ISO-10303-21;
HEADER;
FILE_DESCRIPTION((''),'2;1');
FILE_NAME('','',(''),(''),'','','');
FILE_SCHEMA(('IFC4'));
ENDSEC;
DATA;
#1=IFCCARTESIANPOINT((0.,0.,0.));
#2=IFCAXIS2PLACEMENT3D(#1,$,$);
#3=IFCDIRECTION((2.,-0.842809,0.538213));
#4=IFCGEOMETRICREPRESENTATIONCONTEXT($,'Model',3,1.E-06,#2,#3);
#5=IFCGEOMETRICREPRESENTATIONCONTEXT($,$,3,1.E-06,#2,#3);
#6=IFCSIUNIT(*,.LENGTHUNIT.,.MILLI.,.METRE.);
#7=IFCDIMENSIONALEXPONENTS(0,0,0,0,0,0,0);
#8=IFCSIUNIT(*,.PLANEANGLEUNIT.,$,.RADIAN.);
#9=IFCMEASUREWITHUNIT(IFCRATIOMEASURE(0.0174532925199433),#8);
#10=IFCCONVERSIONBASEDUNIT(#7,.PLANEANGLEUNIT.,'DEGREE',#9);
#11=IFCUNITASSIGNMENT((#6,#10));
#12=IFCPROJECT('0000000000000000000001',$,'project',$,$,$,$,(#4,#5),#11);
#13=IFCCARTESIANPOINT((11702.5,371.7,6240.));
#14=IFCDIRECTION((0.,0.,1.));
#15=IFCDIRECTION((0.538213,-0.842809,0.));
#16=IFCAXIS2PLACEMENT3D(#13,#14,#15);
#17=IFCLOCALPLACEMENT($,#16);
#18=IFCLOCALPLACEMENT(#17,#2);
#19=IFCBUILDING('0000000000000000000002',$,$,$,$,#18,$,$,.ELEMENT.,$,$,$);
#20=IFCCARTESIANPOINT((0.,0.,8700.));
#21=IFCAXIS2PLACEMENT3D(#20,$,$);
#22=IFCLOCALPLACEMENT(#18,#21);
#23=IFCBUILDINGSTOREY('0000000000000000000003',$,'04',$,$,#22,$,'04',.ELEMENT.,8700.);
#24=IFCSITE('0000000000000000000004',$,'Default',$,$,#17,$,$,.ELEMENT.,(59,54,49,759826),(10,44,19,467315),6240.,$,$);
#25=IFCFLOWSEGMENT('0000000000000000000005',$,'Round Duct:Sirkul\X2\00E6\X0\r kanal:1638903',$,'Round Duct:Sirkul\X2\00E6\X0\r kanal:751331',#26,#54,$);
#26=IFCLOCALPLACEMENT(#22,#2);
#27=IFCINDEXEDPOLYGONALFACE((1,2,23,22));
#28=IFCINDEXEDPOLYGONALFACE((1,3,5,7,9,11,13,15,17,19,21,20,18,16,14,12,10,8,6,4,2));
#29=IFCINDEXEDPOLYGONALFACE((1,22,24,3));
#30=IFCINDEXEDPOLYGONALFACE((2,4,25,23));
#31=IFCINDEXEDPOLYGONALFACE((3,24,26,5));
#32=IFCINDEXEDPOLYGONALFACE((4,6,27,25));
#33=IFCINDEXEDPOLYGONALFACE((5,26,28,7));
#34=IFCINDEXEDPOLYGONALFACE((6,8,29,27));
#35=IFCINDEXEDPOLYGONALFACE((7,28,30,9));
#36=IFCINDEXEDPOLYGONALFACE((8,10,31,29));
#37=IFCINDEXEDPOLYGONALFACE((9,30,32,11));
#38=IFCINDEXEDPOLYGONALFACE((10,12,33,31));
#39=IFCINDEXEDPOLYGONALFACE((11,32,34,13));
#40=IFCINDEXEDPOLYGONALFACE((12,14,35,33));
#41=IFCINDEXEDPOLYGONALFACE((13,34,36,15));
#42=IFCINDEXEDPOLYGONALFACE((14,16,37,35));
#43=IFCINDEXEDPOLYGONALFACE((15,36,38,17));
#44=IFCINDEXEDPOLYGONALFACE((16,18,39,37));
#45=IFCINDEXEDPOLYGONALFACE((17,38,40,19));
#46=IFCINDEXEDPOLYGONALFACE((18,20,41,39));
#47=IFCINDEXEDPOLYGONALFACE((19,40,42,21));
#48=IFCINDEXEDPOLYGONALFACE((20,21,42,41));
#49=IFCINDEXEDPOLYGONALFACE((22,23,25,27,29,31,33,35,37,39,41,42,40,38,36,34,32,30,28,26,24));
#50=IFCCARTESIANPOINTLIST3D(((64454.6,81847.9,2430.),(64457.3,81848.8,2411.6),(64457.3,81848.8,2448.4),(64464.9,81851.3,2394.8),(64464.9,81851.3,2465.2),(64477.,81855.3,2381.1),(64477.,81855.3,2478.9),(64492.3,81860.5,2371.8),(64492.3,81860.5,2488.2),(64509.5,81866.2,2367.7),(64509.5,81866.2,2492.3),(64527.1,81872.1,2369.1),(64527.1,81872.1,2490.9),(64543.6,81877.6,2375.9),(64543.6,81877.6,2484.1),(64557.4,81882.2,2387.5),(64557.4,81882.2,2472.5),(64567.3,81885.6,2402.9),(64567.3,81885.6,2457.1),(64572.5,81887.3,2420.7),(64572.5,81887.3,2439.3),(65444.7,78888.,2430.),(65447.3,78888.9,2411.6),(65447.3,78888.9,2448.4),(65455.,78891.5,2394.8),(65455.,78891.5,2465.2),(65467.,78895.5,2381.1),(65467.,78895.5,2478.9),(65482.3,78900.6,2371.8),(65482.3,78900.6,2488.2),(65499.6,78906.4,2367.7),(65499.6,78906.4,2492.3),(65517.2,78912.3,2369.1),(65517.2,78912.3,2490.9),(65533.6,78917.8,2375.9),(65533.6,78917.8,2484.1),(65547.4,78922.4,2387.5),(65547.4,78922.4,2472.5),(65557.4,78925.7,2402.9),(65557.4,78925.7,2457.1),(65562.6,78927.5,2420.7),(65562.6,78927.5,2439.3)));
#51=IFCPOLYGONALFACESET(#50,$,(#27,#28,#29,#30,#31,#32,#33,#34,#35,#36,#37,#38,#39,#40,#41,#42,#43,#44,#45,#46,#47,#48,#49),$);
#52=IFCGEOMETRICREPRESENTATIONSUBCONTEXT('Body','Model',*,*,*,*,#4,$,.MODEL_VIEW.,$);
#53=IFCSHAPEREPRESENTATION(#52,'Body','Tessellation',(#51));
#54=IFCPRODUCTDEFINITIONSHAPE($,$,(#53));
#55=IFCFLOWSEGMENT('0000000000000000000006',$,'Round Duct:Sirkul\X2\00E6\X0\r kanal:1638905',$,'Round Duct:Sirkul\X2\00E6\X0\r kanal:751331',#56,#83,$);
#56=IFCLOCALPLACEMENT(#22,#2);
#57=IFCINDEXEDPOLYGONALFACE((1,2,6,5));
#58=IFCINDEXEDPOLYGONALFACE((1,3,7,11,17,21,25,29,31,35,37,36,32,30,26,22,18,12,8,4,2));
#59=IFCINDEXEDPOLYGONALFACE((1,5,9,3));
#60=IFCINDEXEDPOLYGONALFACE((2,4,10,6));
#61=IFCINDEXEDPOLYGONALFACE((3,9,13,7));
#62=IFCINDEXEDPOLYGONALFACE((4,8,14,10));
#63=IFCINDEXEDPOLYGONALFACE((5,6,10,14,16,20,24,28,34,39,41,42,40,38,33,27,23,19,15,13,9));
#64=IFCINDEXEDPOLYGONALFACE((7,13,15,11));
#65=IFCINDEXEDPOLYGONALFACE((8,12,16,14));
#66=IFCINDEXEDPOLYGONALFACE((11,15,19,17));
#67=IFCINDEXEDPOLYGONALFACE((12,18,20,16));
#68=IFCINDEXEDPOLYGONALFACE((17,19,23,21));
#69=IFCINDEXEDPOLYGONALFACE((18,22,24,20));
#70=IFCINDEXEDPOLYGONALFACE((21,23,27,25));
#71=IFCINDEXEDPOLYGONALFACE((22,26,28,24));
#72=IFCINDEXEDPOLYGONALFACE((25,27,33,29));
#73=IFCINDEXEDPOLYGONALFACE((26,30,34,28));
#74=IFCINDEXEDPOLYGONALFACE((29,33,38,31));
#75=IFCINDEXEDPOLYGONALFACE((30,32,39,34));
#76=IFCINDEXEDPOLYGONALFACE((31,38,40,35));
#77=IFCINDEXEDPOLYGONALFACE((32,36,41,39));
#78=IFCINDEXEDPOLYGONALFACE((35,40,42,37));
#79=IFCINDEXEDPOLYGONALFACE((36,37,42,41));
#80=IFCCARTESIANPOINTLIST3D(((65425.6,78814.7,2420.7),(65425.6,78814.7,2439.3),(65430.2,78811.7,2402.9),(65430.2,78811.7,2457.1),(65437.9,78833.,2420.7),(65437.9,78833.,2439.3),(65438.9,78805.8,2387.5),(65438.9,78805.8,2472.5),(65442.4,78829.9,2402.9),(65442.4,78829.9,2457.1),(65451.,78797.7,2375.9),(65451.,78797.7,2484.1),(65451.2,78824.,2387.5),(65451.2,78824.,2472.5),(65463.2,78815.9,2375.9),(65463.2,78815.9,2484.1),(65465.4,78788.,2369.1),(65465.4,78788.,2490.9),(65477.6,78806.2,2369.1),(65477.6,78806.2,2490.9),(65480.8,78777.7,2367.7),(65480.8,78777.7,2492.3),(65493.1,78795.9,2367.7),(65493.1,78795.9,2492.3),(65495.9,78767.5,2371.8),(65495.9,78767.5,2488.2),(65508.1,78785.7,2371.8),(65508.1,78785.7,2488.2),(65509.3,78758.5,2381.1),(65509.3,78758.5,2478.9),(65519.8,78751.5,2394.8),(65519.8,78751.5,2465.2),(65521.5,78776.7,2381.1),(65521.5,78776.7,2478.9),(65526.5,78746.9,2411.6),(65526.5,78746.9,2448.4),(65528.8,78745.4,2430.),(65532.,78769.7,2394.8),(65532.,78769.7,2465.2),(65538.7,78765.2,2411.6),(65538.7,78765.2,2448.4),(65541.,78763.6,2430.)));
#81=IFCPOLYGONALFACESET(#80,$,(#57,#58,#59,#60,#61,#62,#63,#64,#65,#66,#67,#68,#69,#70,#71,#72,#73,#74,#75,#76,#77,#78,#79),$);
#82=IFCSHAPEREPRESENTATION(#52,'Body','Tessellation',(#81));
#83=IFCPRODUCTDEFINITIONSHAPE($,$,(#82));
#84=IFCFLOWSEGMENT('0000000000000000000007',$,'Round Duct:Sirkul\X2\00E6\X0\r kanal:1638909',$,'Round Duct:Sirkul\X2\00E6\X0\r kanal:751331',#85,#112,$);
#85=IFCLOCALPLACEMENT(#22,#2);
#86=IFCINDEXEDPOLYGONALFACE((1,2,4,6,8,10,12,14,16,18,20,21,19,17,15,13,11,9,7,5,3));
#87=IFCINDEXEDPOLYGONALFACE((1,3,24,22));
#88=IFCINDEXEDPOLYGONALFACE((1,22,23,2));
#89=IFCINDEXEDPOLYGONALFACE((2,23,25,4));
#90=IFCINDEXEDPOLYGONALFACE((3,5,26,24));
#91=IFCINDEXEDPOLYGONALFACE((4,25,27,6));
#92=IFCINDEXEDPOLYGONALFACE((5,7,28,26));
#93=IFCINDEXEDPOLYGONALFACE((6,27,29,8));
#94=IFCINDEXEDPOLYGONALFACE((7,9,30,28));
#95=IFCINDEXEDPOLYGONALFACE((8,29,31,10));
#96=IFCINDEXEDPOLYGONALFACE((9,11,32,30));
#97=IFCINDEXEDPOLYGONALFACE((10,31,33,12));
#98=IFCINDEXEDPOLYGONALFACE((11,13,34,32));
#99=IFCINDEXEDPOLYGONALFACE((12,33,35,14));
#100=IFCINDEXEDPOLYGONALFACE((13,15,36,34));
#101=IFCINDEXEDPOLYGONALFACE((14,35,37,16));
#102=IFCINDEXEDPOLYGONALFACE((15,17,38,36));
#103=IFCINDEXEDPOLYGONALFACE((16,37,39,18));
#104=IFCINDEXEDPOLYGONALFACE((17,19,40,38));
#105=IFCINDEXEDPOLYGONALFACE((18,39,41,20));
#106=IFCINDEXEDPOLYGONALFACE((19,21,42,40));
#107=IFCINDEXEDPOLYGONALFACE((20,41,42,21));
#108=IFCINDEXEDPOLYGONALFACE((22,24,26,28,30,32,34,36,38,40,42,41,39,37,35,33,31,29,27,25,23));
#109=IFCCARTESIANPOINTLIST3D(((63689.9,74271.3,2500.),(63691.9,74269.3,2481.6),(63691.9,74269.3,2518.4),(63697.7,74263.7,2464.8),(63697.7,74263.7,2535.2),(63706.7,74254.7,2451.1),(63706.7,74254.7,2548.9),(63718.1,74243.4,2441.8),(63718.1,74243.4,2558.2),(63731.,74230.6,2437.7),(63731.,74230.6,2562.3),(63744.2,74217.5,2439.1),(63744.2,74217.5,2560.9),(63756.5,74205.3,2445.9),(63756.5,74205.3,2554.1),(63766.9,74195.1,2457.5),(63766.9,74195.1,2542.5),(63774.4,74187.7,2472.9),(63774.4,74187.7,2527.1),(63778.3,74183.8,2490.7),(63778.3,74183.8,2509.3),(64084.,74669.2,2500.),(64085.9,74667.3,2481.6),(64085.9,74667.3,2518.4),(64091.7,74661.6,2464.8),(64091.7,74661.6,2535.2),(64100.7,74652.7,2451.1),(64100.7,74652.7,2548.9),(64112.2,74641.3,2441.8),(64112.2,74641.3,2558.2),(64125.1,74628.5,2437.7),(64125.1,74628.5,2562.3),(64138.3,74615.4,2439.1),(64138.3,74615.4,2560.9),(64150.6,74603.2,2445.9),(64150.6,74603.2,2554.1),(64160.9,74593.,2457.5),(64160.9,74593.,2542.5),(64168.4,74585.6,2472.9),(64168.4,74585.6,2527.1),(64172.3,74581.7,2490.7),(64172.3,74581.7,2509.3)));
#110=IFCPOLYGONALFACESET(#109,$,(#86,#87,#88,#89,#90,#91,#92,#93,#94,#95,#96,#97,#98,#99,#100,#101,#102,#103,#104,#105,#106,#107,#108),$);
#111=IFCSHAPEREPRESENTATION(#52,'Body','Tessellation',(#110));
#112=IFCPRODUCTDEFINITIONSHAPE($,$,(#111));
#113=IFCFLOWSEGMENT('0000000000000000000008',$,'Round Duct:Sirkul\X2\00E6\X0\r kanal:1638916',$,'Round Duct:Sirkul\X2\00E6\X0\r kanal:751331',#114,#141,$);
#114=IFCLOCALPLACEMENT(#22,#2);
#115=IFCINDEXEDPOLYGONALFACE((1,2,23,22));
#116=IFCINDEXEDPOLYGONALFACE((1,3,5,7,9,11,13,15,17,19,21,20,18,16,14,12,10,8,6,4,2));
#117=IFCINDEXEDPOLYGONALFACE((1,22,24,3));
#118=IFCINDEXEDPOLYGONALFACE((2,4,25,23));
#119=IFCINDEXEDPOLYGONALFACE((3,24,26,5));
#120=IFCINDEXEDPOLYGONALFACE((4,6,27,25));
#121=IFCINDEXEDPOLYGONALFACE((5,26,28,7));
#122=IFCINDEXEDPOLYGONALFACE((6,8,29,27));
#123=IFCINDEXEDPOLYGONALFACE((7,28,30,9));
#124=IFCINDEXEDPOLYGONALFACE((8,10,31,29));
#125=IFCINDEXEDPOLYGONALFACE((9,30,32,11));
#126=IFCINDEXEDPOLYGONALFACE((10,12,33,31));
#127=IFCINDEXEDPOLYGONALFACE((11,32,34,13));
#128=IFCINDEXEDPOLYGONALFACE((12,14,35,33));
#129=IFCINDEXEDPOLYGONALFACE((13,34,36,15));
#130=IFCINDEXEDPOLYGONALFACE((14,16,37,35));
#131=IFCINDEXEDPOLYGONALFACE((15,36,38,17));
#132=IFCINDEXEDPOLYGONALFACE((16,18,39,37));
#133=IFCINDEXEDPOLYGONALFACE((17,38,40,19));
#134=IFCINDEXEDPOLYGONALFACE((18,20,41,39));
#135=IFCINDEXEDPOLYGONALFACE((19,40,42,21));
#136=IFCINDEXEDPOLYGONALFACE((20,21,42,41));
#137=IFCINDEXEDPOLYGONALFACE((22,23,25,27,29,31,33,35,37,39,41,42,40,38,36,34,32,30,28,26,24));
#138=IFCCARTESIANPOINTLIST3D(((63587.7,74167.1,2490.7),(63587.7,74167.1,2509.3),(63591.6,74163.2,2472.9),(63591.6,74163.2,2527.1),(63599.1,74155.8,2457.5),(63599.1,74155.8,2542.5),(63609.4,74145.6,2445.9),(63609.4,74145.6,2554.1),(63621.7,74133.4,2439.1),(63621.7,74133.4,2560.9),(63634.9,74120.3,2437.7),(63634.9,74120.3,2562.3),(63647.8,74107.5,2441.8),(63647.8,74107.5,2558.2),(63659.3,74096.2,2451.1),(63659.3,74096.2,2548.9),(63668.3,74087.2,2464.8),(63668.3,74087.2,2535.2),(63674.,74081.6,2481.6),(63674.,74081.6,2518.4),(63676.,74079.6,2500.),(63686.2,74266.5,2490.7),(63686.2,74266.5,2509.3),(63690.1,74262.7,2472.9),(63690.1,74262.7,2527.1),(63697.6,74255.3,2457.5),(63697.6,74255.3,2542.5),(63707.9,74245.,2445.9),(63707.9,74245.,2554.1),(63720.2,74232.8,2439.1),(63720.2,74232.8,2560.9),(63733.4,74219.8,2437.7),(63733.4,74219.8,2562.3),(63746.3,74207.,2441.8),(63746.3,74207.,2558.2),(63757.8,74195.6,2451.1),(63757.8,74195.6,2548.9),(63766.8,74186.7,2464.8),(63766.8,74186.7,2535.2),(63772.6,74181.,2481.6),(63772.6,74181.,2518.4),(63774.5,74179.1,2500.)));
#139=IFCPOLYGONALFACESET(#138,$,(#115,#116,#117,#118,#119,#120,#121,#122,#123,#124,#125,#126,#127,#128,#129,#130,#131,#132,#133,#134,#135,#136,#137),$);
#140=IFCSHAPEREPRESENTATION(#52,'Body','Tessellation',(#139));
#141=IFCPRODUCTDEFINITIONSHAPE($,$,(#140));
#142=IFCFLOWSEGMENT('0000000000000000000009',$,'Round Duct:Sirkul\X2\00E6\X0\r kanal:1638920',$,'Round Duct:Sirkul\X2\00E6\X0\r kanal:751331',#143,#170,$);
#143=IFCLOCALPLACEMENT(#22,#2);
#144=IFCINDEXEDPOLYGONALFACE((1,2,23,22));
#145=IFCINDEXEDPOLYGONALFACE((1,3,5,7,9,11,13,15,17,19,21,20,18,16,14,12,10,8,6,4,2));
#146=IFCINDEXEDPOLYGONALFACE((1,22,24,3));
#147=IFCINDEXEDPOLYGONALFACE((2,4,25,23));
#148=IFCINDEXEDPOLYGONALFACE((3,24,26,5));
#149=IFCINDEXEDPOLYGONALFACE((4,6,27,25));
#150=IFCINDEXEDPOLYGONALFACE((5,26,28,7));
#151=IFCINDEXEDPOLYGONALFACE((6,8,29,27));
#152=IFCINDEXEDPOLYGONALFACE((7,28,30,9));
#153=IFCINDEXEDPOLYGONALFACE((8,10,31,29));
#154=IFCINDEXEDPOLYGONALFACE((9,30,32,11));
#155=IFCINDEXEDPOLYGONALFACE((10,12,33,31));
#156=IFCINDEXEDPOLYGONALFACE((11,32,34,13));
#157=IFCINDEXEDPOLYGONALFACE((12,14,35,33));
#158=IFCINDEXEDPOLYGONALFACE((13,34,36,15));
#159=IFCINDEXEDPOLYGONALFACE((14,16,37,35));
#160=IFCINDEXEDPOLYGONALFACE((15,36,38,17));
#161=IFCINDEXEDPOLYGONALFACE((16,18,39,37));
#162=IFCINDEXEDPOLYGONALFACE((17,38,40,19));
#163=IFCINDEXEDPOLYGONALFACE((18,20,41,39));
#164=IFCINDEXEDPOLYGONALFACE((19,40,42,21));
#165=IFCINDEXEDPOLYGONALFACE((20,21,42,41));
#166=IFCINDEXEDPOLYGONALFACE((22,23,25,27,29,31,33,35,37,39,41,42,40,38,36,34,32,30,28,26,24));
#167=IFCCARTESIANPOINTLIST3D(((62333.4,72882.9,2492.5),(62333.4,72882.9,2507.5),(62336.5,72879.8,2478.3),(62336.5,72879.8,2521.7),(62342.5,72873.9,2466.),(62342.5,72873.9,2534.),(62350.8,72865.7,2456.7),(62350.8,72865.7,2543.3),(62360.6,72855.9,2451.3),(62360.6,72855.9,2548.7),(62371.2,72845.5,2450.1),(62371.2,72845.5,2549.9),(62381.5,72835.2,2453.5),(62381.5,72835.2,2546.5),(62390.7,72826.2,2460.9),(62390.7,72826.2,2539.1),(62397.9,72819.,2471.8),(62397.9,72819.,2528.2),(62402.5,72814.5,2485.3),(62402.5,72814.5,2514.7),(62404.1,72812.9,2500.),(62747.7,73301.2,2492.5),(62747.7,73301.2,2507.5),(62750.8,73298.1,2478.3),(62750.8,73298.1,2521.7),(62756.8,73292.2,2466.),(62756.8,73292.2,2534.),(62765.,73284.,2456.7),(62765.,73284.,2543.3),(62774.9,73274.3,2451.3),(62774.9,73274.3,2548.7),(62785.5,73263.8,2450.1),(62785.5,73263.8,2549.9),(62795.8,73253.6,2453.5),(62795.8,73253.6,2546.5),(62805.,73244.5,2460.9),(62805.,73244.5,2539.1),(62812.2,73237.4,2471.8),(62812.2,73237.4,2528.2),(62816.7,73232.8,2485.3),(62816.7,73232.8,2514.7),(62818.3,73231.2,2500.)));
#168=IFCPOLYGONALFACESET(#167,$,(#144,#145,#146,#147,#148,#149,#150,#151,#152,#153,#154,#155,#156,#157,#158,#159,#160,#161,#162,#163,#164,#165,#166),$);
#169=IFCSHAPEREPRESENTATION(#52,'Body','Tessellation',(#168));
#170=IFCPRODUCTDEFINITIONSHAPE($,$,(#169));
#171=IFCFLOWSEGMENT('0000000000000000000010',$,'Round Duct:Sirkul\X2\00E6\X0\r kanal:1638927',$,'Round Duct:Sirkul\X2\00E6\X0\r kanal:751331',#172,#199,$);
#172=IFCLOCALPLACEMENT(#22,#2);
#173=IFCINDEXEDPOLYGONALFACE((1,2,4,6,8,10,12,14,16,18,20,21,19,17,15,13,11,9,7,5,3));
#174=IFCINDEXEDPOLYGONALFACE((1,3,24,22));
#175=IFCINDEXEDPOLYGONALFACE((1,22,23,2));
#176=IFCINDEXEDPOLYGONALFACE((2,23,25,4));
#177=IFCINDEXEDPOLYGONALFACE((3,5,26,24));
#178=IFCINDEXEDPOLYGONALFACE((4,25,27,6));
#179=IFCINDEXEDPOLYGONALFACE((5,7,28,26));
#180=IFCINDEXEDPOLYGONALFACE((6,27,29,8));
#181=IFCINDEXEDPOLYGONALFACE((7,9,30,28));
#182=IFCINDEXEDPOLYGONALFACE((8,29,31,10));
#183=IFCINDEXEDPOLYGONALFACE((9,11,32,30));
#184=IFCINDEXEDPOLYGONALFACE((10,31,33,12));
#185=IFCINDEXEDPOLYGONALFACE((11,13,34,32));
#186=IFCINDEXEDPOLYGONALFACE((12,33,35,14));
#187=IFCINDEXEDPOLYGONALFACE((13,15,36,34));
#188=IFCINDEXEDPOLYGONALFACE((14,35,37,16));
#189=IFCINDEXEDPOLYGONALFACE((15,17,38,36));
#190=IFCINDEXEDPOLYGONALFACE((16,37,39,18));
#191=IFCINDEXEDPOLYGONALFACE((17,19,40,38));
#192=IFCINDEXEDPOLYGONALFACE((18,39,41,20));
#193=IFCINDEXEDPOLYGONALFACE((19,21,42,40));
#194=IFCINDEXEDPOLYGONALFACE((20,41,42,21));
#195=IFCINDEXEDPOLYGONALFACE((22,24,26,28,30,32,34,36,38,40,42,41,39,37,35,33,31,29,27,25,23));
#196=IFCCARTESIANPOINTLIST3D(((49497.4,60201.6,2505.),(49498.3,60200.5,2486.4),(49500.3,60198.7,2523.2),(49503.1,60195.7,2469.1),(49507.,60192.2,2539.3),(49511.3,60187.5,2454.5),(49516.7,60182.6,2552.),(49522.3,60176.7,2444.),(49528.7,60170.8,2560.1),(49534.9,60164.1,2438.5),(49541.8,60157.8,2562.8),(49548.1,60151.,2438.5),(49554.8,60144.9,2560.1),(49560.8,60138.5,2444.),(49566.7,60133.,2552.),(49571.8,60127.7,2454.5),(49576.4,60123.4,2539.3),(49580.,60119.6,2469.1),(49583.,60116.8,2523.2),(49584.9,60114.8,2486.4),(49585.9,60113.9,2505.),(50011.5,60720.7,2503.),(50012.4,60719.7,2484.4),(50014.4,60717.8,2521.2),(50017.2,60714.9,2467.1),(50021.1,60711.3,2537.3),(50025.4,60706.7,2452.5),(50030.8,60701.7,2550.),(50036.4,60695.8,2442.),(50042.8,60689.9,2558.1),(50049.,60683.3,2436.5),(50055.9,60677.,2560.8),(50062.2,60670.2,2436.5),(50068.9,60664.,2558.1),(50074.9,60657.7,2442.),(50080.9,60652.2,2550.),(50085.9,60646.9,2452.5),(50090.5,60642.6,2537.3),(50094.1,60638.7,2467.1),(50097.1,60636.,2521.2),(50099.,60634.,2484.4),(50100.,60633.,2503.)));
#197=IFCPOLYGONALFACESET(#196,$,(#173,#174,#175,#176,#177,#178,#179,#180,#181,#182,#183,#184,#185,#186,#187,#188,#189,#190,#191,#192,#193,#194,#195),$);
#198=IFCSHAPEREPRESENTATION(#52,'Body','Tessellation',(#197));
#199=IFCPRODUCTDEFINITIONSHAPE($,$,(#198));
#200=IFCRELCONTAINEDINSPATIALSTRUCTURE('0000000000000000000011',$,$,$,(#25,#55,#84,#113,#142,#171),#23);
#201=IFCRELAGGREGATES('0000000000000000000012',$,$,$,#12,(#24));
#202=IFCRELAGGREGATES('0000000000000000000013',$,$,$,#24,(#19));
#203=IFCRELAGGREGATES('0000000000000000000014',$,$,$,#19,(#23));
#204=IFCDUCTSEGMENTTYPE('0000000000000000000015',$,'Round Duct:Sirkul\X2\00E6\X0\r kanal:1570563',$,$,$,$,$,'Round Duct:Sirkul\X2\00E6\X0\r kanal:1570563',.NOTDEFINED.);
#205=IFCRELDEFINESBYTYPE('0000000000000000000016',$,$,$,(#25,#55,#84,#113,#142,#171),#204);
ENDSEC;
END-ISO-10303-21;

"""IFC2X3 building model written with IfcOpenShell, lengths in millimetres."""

from ifc_helpers import new_model, entity, si_unit, converted_unit, direction, frame, frame_2d, origin, origin_2d_with_axis, place, context, subcontext, project, spatial, circle, extrude, type_object, element, save


model = new_model("IFC2X3")

# Units and contexts
model_context = context("Model", 3, precision=1e-06, world=origin(), true_north=direction((2.0, -0.842809, 0.538213)))
context_of_model = context(None, 3, precision=1e-06, world=origin(), true_north=direction((2.0, -0.842809, 0.538213)))
body_context = subcontext(model_context, "Body", "Model", "MODEL_VIEW")
ifc_project = project(units=[si_unit("LENGTHUNIT", "METRE", prefix="MILLI"), converted_unit("PLANEANGLEUNIT", "DEGREE", entity("IfcRatioMeasure", 0.0174532925199433), si_unit("PLANEANGLEUNIT", "RADIAN"), dimensions=[0, 0, 0, 0, 0, 0, 0])], contexts=[model_context, context_of_model])

# Site, building, storey
site_placement = place(None, frame((11702.5, 371.7, 6240.0), z_axis=(0.0, 0.0, 1.0), x_axis=(0.538213, -0.842809, 0.0)))
site = spatial("IfcSite", under=ifc_project, at=site_placement, Name="Default", CompositionType="ELEMENT", RefLatitude=(59, 54, 49, 759826), RefLongitude=(10, 44, 19, 467315), RefElevation=6240.0)
building_placement = place(site_placement, origin())
building = spatial("IfcBuilding", under=site, at=building_placement, CompositionType="ELEMENT")
storey_placement = place(building_placement, frame((0.0, 0.0, 8700.0)))
storey = spatial("IfcBuildingStorey", under=building, at=storey_placement, Name="04", LongName="04", CompositionType="ELEMENT", Elevation=8700.0)

# Flow segments
duct_segment_type = type_object("IfcDuctSegmentType", Name="Round Duct:Sirkulær kanal:1570563", ElementType="Round Duct:Sirkulær kanal:1570563", PredefinedType="NOTDEFINED")
flow_segment_1_placement = place(storey_placement, origin())
element("IfcFlowSegment", 1, at=flow_segment_1_placement, inside=storey, type_object=duct_segment_type, Name="Round Duct:Sirkulær kanal:1638903", ObjectType="Round Duct:Sirkulær kanal:751331", context=body_context, shape_type="SweptSolid", body=[
    extrude(circle(Radius=62.5, at=origin_2d_with_axis()), frame((64513.9, 81867.7, 2430.0), z_axis=(0.317224, -0.948351, 0.0), x_axis=(-0.948351, -0.317224, 0.0)), (0.0, 0.0, 1.0), 3121.0),
])
flow_segment_2_placement = place(storey_placement, origin())
element("IfcFlowSegment", 2, at=flow_segment_2_placement, inside=storey, type_object=duct_segment_type, Name="Round Duct:Sirkulær kanal:1638905", ObjectType="Round Duct:Sirkulær kanal:751331", context=body_context, shape_type="SweptSolid", body=[
    extrude(circle(Radius=62.5, at=frame_2d((0.0, 0.0), x_axis=(1.0, 0.0))), frame((65476.9, 78780.3, 2430.0), z_axis=(0.557892, 0.829913, 0.0), x_axis=(0.829913, -0.557892, 0.0)), (0.0, 0.0, 1.0), 21.9),
])
flow_segment_3_placement = place(storey_placement, origin())
element("IfcFlowSegment", 3, at=flow_segment_3_placement, inside=storey, type_object=duct_segment_type, Name="Round Duct:Sirkulær kanal:1638909", ObjectType="Round Duct:Sirkulær kanal:751331", context=body_context, shape_type="SweptSolid", body=[
    extrude(circle(Radius=62.5, at=origin_2d_with_axis()), frame((63734.3, 74227.3, 2500.0), z_axis=(0.703643, 0.710554, 0.0), x_axis=(-0.710554, 0.703643, 0.0)), (0.0, 0.0, 1.0), 560.0),
])
flow_segment_4_placement = place(storey_placement, origin())
element("IfcFlowSegment", 4, at=flow_segment_4_placement, inside=storey, type_object=duct_segment_type, Name="Round Duct:Sirkulær kanal:1638916", ObjectType="Round Duct:Sirkulær kanal:751331", context=body_context, shape_type="SweptSolid", body=[
    extrude(circle(Radius=62.5, at=origin_2d_with_axis()), frame((63631.6, 74123.6, 2500.0), z_axis=(0.703643, 0.710554, 0.0), x_axis=(0.710554, -0.703643, 0.0)), (0.0, 0.0, 1.0), 140.0),
])
flow_segment_5_placement = place(storey_placement, origin())
element("IfcFlowSegment", 5, at=flow_segment_5_placement, inside=storey, type_object=duct_segment_type, Name="Round Duct:Sirkulær kanal:1638920", ObjectType="Round Duct:Sirkulær kanal:751331", context=body_context, shape_type="SweptSolid", body=[
    extrude(circle(Radius=50.0, at=origin_2d_with_axis()), frame((62368.5, 72848.1, 2500.0), z_axis=(0.703643, 0.710554, 0.0), x_axis=(0.710554, -0.703643, 0.0)), (0.0, 0.0, 1.0), 588.8),
])
flow_segment_6_placement = place(storey_placement, origin())
element("IfcFlowSegment", 6, at=flow_segment_6_placement, inside=storey, type_object=duct_segment_type, Name="Round Duct:Sirkulær kanal:1638927", ObjectType="Round Duct:Sirkulær kanal:751331", context=body_context, shape_type="SweptSolid", body=[
    extrude(circle(Radius=62.5, at=origin_2d_with_axis()), frame((49541.6, 60157.7, 2500.3), z_axis=(0.703638, 0.710553, -0.002727), x_axis=(0.001919, 0.001938, 0.999996)), (0.0, 0.0, 1.0), 730.6),
])

save(model, "model.ifc")
